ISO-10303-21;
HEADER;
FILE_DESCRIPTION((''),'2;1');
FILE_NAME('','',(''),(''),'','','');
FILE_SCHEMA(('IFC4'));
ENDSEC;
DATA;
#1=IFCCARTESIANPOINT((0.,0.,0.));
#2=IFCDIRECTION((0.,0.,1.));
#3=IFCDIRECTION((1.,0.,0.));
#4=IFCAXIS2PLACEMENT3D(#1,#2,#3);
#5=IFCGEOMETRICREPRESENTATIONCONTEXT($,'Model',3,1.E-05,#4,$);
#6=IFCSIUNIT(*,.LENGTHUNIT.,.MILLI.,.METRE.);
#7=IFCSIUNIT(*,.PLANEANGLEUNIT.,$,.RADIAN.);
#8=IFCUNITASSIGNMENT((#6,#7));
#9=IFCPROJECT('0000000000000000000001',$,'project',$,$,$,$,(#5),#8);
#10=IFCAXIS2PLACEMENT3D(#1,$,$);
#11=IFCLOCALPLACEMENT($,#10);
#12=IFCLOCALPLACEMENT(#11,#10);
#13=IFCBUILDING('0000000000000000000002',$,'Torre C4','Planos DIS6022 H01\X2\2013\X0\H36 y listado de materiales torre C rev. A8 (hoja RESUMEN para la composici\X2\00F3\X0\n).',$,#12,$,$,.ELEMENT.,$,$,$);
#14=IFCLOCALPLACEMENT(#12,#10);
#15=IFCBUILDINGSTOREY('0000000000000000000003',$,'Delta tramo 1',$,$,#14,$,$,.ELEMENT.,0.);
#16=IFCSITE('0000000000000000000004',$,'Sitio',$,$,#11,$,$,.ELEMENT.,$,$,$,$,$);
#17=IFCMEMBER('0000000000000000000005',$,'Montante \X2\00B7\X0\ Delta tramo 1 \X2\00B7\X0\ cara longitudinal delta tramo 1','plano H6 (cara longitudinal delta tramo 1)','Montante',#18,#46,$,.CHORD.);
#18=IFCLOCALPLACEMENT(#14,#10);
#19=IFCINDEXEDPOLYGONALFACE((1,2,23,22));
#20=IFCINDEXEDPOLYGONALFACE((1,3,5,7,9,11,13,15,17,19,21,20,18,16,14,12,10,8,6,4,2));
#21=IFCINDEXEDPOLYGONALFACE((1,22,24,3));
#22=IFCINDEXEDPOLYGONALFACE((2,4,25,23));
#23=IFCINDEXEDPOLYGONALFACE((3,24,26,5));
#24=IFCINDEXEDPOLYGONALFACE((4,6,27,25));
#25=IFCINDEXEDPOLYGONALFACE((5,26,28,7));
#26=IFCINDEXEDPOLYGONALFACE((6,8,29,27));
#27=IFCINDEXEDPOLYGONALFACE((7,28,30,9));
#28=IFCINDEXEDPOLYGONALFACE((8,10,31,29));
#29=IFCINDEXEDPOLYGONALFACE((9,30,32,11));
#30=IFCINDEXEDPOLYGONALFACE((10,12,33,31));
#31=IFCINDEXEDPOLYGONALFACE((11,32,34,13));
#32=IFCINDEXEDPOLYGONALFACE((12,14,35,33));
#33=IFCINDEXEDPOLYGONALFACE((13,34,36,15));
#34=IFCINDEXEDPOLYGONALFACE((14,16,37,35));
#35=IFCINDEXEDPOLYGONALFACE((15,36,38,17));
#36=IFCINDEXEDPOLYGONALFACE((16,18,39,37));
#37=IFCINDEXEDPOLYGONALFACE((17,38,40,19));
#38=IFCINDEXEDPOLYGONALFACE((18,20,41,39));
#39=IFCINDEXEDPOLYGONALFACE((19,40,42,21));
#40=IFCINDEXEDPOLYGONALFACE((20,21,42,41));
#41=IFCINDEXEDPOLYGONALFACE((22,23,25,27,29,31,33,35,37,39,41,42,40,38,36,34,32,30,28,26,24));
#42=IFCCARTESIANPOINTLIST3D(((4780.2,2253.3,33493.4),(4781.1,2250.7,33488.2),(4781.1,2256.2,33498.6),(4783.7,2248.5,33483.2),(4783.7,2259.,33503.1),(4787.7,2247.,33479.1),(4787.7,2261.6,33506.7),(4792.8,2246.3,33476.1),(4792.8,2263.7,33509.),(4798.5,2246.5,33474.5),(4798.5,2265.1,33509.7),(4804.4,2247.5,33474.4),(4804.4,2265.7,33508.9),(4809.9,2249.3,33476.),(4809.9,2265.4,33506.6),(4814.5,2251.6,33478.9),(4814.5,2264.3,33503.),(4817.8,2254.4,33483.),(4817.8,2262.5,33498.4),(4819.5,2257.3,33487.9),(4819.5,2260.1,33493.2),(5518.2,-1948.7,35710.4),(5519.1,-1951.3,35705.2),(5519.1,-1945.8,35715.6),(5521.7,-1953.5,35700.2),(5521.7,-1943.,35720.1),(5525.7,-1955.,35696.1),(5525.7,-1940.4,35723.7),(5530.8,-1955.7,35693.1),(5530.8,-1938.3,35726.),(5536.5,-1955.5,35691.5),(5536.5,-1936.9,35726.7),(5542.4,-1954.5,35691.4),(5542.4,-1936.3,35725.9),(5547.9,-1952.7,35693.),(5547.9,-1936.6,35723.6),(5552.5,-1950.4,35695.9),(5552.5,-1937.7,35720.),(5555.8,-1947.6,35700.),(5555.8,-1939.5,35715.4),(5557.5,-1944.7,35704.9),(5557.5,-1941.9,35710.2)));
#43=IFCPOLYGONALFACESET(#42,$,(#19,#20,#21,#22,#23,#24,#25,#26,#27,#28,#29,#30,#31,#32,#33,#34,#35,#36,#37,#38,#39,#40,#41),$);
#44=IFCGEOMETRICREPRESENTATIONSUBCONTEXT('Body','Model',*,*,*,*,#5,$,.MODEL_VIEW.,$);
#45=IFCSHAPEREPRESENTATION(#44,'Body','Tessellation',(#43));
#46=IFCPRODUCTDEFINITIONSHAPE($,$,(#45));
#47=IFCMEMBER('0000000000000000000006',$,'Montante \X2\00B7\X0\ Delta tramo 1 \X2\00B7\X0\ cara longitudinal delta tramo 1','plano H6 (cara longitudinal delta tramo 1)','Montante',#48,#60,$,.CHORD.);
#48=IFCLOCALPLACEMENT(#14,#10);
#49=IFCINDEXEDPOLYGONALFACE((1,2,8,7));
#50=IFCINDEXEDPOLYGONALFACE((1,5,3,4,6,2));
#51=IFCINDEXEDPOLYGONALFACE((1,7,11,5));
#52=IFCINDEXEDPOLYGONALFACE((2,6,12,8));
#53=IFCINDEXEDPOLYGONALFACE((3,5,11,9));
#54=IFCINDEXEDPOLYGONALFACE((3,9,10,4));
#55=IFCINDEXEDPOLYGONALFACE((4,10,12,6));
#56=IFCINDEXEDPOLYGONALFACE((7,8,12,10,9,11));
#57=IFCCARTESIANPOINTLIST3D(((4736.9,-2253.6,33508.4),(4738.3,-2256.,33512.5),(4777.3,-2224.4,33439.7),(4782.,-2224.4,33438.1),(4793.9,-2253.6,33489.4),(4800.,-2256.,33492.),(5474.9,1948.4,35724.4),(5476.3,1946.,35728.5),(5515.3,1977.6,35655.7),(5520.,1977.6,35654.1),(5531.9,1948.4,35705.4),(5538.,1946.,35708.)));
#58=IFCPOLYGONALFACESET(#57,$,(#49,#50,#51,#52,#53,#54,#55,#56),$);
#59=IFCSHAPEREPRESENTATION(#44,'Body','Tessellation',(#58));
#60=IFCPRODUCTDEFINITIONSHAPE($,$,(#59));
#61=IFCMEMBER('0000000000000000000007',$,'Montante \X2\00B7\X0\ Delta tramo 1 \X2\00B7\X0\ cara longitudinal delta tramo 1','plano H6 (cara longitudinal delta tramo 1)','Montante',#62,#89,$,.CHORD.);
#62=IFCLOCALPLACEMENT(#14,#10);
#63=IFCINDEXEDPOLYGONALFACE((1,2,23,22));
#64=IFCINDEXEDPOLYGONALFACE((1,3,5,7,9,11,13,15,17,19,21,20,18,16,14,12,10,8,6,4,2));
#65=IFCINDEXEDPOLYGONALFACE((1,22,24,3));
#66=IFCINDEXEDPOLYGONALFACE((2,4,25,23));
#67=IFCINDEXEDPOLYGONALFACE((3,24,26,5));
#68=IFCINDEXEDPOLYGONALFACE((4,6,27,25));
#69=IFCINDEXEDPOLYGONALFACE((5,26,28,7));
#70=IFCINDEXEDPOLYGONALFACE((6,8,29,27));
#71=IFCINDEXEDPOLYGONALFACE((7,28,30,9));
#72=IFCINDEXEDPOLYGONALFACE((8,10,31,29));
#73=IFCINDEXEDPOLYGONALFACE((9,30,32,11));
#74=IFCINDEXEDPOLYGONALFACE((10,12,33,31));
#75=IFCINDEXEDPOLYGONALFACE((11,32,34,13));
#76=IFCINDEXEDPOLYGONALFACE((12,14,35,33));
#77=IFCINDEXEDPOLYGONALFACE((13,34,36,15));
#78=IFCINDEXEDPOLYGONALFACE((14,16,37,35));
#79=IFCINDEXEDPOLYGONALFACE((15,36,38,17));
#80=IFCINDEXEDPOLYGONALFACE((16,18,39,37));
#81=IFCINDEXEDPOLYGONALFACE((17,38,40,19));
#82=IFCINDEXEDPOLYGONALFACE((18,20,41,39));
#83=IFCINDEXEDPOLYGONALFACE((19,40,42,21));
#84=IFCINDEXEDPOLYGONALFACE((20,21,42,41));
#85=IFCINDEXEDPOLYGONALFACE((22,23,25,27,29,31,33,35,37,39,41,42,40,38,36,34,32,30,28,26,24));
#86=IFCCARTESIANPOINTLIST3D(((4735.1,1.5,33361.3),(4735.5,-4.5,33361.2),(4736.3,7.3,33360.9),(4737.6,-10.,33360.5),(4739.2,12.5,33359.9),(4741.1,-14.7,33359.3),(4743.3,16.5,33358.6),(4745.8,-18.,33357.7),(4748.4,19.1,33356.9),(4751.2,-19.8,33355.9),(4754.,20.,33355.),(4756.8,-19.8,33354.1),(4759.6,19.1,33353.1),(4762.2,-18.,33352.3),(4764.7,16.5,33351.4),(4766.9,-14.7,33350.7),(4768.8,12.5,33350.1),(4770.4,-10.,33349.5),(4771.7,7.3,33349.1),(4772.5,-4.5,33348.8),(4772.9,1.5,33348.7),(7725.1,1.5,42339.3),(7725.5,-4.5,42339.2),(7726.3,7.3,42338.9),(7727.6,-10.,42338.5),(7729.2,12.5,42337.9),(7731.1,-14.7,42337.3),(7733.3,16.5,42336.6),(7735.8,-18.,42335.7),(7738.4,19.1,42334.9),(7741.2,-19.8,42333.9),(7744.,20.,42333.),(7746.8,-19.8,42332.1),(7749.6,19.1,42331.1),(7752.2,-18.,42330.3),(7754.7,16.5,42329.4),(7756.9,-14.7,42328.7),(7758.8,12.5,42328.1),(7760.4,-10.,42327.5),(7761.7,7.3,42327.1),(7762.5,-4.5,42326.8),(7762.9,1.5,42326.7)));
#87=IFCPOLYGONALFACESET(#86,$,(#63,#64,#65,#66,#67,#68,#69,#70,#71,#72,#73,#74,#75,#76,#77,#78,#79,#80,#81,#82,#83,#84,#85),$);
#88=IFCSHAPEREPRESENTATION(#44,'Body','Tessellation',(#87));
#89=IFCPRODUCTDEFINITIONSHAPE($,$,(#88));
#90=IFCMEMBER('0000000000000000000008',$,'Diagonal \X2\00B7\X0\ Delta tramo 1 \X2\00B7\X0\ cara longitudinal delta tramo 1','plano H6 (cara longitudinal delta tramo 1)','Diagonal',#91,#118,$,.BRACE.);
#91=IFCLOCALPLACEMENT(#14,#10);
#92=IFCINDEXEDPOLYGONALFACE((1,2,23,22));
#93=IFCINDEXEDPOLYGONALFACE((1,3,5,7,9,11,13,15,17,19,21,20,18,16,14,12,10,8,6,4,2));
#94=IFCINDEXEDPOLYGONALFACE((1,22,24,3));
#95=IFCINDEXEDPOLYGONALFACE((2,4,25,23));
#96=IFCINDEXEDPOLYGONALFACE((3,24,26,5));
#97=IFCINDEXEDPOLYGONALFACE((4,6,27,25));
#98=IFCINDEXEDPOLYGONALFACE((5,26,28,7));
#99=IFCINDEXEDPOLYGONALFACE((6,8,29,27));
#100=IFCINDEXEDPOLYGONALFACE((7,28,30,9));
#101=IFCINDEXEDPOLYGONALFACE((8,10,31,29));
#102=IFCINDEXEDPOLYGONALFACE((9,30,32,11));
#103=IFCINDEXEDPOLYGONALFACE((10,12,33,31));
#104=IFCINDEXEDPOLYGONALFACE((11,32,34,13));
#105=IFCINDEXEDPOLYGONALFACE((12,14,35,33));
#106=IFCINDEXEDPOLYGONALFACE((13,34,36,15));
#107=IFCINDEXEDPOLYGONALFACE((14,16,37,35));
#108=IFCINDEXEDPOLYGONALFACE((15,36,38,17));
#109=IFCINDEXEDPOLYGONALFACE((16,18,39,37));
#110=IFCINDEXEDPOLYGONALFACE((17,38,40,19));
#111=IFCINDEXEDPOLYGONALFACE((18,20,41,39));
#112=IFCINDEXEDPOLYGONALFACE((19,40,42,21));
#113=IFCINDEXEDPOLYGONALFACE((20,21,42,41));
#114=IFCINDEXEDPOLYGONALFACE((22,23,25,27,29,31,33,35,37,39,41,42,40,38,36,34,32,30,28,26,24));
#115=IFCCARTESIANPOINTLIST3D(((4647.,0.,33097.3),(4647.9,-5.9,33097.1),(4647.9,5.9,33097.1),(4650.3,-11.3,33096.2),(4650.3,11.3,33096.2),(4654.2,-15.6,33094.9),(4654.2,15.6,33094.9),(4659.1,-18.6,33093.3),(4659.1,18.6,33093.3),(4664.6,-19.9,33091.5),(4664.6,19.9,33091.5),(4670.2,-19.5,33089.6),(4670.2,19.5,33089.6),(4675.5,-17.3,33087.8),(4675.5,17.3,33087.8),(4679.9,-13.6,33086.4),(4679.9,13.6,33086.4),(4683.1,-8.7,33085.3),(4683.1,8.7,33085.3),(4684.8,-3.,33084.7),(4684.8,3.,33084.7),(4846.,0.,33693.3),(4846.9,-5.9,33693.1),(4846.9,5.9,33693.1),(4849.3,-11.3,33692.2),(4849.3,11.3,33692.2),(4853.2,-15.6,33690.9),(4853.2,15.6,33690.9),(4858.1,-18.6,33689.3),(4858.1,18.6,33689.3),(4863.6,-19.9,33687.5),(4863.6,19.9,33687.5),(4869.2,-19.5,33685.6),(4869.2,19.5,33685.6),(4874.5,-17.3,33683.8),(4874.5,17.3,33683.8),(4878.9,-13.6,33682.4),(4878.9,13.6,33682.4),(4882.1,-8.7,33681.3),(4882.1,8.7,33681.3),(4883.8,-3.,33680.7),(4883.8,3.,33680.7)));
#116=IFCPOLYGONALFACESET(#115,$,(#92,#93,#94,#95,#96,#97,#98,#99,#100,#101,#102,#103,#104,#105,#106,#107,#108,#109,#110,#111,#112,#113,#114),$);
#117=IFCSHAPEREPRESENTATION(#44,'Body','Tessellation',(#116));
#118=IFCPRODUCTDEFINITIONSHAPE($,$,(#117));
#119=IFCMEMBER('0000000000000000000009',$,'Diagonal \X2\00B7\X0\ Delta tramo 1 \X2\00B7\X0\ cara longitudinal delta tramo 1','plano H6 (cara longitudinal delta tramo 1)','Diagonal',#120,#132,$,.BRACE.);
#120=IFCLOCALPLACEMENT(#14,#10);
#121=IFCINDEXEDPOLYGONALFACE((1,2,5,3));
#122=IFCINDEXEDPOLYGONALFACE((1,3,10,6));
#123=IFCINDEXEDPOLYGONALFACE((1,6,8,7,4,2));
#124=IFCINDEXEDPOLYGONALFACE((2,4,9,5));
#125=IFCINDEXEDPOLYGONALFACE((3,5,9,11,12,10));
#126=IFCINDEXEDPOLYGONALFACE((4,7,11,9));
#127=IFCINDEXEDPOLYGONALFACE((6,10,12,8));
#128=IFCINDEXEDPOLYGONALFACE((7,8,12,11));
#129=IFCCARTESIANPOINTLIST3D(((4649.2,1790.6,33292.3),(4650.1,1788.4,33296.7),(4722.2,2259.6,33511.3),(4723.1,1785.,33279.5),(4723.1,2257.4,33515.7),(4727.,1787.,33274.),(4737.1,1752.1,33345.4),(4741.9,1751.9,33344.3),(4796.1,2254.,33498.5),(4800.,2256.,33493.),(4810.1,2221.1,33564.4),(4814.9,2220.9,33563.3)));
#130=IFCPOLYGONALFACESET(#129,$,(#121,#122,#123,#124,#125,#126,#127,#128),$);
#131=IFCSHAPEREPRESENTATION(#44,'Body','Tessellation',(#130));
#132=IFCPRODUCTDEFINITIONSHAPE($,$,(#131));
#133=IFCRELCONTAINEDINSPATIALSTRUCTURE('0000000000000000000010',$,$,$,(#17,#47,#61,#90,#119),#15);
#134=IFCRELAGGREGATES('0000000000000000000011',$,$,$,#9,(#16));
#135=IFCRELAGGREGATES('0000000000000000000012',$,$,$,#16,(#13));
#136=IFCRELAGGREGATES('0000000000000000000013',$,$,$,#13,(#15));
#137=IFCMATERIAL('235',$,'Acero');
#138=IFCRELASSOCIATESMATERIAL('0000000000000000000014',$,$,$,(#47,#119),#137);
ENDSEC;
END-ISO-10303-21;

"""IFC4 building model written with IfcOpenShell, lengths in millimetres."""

from ifc_helpers import new_model, si_unit, frame, frame_2d, origin, origin_with_axes, place, context, subcontext, project, spatial, circle, l_section, extrude, material, element, save


model = new_model("IFC4")

# Units and contexts
model_context = context("Model", 3, precision=1e-05, world=origin_with_axes())
body_context = subcontext(model_context, "Body", "Model", "MODEL_VIEW")
ifc_project = project(units=[si_unit("LENGTHUNIT", "METRE", prefix="MILLI"), si_unit("PLANEANGLEUNIT", "RADIAN")], contexts=[model_context])

# Site, building, storey
site_placement = place(None, origin())
site = spatial("IfcSite", under=ifc_project, at=site_placement, Name="Sitio", CompositionType="ELEMENT")
building_placement = place(site_placement, origin())
building = spatial("IfcBuilding", under=site, at=building_placement, Name="Torre C4", Description="Planos DIS6022 H01–H36 y listado de materiales torre C rev. A8 (hoja RESUMEN para la composición).", CompositionType="ELEMENT")
storey_placement = place(building_placement, origin())
storey = spatial("IfcBuildingStorey", under=building, at=storey_placement, Name="Delta tramo 1", CompositionType="ELEMENT", Elevation=0.0)

# Members
member_1_placement = place(storey_placement, frame((4800.0, 2256.0, 33492.0), z_axis=(0.153495, -0.873966, 0.46111), x_axis=(-0.988149, -0.135759, 0.071627)))
element("IfcMember", 1, at=member_1_placement, inside=storey, Name="Montante · Delta tramo 1 · cara longitudinal delta tramo 1", Description="plano H6 (cara longitudinal delta tramo 1)", ObjectType="Montante", PredefinedType="CHORD", context=body_context, shape_type="SweptSolid", body=[
    extrude(circle(Radius=20.0), None, (0.0, 0.0, 1.0), 4808.0),
])
ifc_material_1 = material(Name="235", Category="Acero")
member_2_placement = place(storey_placement, frame((4800.0, -2256.0, 33492.0), z_axis=(0.15351, 0.87405, 0.460946), x_axis=(-0.276174, 0.485836, -0.829272)))
element("IfcMember", 2, at=member_2_placement, inside=storey, material=ifc_material_1, Name="Montante · Delta tramo 1 · cara longitudinal delta tramo 1", Description="plano H6 (cara longitudinal delta tramo 1)", ObjectType="Montante", PredefinedType="CHORD", context=body_context, shape_type="SweptSolid", body=[
    extrude(l_section(Depth=65.0, Width=65.0, Thickness=5.0, at=frame_2d((32.5, 32.5))), None, (0.0, 0.0, 1.0), 4807.5),
])
member_3_placement = place(storey_placement, frame((4754.0, 0.0, 33355.0), z_axis=(0.315974, 0.0, 0.948768), x_axis=(0.0, 1.0, 0.0)))
element("IfcMember", 3, at=member_3_placement, inside=storey, Name="Montante · Delta tramo 1 · cara longitudinal delta tramo 1", Description="plano H6 (cara longitudinal delta tramo 1)", ObjectType="Montante", PredefinedType="CHORD", context=body_context, shape_type="SweptSolid", body=[
    extrude(circle(Radius=20.0), None, (0.0, 0.0, 1.0), 9462.8),
])
member_4_placement = place(storey_placement, frame((4666.0, 0.0, 33091.0), z_axis=(0.316705, 0.0, 0.948524), x_axis=(-0.948524, 0.0, 0.316705)))
element("IfcMember", 4, at=member_4_placement, inside=storey, Name="Diagonal · Delta tramo 1 · cara longitudinal delta tramo 1", Description="plano H6 (cara longitudinal delta tramo 1)", ObjectType="Diagonal", PredefinedType="BRACE", context=body_context, shape_type="SweptSolid", body=[
    extrude(circle(Radius=20.0), None, (0.0, 0.0, 1.0), 628.3),
])
member_5_placement = place(storey_placement, frame((4727.0, 1787.0, 33274.0), z_axis=(0.13965, 0.897206, 0.418951), x_axis=(-0.972489, 0.044604, 0.22864)))
element("IfcMember", 5, at=member_5_placement, inside=storey, material=ifc_material_1, Name="Diagonal · Delta tramo 1 · cara longitudinal delta tramo 1", Description="plano H6 (cara longitudinal delta tramo 1)", ObjectType="Diagonal", PredefinedType="BRACE", context=body_context, shape_type="SweptSolid", body=[
    extrude(l_section(Depth=80.0, Width=80.0, Thickness=5.0, at=frame_2d((40.0, 40.0))), None, (0.0, 0.0, 1.0), 522.7),
])

save(model, "model.ifc")
